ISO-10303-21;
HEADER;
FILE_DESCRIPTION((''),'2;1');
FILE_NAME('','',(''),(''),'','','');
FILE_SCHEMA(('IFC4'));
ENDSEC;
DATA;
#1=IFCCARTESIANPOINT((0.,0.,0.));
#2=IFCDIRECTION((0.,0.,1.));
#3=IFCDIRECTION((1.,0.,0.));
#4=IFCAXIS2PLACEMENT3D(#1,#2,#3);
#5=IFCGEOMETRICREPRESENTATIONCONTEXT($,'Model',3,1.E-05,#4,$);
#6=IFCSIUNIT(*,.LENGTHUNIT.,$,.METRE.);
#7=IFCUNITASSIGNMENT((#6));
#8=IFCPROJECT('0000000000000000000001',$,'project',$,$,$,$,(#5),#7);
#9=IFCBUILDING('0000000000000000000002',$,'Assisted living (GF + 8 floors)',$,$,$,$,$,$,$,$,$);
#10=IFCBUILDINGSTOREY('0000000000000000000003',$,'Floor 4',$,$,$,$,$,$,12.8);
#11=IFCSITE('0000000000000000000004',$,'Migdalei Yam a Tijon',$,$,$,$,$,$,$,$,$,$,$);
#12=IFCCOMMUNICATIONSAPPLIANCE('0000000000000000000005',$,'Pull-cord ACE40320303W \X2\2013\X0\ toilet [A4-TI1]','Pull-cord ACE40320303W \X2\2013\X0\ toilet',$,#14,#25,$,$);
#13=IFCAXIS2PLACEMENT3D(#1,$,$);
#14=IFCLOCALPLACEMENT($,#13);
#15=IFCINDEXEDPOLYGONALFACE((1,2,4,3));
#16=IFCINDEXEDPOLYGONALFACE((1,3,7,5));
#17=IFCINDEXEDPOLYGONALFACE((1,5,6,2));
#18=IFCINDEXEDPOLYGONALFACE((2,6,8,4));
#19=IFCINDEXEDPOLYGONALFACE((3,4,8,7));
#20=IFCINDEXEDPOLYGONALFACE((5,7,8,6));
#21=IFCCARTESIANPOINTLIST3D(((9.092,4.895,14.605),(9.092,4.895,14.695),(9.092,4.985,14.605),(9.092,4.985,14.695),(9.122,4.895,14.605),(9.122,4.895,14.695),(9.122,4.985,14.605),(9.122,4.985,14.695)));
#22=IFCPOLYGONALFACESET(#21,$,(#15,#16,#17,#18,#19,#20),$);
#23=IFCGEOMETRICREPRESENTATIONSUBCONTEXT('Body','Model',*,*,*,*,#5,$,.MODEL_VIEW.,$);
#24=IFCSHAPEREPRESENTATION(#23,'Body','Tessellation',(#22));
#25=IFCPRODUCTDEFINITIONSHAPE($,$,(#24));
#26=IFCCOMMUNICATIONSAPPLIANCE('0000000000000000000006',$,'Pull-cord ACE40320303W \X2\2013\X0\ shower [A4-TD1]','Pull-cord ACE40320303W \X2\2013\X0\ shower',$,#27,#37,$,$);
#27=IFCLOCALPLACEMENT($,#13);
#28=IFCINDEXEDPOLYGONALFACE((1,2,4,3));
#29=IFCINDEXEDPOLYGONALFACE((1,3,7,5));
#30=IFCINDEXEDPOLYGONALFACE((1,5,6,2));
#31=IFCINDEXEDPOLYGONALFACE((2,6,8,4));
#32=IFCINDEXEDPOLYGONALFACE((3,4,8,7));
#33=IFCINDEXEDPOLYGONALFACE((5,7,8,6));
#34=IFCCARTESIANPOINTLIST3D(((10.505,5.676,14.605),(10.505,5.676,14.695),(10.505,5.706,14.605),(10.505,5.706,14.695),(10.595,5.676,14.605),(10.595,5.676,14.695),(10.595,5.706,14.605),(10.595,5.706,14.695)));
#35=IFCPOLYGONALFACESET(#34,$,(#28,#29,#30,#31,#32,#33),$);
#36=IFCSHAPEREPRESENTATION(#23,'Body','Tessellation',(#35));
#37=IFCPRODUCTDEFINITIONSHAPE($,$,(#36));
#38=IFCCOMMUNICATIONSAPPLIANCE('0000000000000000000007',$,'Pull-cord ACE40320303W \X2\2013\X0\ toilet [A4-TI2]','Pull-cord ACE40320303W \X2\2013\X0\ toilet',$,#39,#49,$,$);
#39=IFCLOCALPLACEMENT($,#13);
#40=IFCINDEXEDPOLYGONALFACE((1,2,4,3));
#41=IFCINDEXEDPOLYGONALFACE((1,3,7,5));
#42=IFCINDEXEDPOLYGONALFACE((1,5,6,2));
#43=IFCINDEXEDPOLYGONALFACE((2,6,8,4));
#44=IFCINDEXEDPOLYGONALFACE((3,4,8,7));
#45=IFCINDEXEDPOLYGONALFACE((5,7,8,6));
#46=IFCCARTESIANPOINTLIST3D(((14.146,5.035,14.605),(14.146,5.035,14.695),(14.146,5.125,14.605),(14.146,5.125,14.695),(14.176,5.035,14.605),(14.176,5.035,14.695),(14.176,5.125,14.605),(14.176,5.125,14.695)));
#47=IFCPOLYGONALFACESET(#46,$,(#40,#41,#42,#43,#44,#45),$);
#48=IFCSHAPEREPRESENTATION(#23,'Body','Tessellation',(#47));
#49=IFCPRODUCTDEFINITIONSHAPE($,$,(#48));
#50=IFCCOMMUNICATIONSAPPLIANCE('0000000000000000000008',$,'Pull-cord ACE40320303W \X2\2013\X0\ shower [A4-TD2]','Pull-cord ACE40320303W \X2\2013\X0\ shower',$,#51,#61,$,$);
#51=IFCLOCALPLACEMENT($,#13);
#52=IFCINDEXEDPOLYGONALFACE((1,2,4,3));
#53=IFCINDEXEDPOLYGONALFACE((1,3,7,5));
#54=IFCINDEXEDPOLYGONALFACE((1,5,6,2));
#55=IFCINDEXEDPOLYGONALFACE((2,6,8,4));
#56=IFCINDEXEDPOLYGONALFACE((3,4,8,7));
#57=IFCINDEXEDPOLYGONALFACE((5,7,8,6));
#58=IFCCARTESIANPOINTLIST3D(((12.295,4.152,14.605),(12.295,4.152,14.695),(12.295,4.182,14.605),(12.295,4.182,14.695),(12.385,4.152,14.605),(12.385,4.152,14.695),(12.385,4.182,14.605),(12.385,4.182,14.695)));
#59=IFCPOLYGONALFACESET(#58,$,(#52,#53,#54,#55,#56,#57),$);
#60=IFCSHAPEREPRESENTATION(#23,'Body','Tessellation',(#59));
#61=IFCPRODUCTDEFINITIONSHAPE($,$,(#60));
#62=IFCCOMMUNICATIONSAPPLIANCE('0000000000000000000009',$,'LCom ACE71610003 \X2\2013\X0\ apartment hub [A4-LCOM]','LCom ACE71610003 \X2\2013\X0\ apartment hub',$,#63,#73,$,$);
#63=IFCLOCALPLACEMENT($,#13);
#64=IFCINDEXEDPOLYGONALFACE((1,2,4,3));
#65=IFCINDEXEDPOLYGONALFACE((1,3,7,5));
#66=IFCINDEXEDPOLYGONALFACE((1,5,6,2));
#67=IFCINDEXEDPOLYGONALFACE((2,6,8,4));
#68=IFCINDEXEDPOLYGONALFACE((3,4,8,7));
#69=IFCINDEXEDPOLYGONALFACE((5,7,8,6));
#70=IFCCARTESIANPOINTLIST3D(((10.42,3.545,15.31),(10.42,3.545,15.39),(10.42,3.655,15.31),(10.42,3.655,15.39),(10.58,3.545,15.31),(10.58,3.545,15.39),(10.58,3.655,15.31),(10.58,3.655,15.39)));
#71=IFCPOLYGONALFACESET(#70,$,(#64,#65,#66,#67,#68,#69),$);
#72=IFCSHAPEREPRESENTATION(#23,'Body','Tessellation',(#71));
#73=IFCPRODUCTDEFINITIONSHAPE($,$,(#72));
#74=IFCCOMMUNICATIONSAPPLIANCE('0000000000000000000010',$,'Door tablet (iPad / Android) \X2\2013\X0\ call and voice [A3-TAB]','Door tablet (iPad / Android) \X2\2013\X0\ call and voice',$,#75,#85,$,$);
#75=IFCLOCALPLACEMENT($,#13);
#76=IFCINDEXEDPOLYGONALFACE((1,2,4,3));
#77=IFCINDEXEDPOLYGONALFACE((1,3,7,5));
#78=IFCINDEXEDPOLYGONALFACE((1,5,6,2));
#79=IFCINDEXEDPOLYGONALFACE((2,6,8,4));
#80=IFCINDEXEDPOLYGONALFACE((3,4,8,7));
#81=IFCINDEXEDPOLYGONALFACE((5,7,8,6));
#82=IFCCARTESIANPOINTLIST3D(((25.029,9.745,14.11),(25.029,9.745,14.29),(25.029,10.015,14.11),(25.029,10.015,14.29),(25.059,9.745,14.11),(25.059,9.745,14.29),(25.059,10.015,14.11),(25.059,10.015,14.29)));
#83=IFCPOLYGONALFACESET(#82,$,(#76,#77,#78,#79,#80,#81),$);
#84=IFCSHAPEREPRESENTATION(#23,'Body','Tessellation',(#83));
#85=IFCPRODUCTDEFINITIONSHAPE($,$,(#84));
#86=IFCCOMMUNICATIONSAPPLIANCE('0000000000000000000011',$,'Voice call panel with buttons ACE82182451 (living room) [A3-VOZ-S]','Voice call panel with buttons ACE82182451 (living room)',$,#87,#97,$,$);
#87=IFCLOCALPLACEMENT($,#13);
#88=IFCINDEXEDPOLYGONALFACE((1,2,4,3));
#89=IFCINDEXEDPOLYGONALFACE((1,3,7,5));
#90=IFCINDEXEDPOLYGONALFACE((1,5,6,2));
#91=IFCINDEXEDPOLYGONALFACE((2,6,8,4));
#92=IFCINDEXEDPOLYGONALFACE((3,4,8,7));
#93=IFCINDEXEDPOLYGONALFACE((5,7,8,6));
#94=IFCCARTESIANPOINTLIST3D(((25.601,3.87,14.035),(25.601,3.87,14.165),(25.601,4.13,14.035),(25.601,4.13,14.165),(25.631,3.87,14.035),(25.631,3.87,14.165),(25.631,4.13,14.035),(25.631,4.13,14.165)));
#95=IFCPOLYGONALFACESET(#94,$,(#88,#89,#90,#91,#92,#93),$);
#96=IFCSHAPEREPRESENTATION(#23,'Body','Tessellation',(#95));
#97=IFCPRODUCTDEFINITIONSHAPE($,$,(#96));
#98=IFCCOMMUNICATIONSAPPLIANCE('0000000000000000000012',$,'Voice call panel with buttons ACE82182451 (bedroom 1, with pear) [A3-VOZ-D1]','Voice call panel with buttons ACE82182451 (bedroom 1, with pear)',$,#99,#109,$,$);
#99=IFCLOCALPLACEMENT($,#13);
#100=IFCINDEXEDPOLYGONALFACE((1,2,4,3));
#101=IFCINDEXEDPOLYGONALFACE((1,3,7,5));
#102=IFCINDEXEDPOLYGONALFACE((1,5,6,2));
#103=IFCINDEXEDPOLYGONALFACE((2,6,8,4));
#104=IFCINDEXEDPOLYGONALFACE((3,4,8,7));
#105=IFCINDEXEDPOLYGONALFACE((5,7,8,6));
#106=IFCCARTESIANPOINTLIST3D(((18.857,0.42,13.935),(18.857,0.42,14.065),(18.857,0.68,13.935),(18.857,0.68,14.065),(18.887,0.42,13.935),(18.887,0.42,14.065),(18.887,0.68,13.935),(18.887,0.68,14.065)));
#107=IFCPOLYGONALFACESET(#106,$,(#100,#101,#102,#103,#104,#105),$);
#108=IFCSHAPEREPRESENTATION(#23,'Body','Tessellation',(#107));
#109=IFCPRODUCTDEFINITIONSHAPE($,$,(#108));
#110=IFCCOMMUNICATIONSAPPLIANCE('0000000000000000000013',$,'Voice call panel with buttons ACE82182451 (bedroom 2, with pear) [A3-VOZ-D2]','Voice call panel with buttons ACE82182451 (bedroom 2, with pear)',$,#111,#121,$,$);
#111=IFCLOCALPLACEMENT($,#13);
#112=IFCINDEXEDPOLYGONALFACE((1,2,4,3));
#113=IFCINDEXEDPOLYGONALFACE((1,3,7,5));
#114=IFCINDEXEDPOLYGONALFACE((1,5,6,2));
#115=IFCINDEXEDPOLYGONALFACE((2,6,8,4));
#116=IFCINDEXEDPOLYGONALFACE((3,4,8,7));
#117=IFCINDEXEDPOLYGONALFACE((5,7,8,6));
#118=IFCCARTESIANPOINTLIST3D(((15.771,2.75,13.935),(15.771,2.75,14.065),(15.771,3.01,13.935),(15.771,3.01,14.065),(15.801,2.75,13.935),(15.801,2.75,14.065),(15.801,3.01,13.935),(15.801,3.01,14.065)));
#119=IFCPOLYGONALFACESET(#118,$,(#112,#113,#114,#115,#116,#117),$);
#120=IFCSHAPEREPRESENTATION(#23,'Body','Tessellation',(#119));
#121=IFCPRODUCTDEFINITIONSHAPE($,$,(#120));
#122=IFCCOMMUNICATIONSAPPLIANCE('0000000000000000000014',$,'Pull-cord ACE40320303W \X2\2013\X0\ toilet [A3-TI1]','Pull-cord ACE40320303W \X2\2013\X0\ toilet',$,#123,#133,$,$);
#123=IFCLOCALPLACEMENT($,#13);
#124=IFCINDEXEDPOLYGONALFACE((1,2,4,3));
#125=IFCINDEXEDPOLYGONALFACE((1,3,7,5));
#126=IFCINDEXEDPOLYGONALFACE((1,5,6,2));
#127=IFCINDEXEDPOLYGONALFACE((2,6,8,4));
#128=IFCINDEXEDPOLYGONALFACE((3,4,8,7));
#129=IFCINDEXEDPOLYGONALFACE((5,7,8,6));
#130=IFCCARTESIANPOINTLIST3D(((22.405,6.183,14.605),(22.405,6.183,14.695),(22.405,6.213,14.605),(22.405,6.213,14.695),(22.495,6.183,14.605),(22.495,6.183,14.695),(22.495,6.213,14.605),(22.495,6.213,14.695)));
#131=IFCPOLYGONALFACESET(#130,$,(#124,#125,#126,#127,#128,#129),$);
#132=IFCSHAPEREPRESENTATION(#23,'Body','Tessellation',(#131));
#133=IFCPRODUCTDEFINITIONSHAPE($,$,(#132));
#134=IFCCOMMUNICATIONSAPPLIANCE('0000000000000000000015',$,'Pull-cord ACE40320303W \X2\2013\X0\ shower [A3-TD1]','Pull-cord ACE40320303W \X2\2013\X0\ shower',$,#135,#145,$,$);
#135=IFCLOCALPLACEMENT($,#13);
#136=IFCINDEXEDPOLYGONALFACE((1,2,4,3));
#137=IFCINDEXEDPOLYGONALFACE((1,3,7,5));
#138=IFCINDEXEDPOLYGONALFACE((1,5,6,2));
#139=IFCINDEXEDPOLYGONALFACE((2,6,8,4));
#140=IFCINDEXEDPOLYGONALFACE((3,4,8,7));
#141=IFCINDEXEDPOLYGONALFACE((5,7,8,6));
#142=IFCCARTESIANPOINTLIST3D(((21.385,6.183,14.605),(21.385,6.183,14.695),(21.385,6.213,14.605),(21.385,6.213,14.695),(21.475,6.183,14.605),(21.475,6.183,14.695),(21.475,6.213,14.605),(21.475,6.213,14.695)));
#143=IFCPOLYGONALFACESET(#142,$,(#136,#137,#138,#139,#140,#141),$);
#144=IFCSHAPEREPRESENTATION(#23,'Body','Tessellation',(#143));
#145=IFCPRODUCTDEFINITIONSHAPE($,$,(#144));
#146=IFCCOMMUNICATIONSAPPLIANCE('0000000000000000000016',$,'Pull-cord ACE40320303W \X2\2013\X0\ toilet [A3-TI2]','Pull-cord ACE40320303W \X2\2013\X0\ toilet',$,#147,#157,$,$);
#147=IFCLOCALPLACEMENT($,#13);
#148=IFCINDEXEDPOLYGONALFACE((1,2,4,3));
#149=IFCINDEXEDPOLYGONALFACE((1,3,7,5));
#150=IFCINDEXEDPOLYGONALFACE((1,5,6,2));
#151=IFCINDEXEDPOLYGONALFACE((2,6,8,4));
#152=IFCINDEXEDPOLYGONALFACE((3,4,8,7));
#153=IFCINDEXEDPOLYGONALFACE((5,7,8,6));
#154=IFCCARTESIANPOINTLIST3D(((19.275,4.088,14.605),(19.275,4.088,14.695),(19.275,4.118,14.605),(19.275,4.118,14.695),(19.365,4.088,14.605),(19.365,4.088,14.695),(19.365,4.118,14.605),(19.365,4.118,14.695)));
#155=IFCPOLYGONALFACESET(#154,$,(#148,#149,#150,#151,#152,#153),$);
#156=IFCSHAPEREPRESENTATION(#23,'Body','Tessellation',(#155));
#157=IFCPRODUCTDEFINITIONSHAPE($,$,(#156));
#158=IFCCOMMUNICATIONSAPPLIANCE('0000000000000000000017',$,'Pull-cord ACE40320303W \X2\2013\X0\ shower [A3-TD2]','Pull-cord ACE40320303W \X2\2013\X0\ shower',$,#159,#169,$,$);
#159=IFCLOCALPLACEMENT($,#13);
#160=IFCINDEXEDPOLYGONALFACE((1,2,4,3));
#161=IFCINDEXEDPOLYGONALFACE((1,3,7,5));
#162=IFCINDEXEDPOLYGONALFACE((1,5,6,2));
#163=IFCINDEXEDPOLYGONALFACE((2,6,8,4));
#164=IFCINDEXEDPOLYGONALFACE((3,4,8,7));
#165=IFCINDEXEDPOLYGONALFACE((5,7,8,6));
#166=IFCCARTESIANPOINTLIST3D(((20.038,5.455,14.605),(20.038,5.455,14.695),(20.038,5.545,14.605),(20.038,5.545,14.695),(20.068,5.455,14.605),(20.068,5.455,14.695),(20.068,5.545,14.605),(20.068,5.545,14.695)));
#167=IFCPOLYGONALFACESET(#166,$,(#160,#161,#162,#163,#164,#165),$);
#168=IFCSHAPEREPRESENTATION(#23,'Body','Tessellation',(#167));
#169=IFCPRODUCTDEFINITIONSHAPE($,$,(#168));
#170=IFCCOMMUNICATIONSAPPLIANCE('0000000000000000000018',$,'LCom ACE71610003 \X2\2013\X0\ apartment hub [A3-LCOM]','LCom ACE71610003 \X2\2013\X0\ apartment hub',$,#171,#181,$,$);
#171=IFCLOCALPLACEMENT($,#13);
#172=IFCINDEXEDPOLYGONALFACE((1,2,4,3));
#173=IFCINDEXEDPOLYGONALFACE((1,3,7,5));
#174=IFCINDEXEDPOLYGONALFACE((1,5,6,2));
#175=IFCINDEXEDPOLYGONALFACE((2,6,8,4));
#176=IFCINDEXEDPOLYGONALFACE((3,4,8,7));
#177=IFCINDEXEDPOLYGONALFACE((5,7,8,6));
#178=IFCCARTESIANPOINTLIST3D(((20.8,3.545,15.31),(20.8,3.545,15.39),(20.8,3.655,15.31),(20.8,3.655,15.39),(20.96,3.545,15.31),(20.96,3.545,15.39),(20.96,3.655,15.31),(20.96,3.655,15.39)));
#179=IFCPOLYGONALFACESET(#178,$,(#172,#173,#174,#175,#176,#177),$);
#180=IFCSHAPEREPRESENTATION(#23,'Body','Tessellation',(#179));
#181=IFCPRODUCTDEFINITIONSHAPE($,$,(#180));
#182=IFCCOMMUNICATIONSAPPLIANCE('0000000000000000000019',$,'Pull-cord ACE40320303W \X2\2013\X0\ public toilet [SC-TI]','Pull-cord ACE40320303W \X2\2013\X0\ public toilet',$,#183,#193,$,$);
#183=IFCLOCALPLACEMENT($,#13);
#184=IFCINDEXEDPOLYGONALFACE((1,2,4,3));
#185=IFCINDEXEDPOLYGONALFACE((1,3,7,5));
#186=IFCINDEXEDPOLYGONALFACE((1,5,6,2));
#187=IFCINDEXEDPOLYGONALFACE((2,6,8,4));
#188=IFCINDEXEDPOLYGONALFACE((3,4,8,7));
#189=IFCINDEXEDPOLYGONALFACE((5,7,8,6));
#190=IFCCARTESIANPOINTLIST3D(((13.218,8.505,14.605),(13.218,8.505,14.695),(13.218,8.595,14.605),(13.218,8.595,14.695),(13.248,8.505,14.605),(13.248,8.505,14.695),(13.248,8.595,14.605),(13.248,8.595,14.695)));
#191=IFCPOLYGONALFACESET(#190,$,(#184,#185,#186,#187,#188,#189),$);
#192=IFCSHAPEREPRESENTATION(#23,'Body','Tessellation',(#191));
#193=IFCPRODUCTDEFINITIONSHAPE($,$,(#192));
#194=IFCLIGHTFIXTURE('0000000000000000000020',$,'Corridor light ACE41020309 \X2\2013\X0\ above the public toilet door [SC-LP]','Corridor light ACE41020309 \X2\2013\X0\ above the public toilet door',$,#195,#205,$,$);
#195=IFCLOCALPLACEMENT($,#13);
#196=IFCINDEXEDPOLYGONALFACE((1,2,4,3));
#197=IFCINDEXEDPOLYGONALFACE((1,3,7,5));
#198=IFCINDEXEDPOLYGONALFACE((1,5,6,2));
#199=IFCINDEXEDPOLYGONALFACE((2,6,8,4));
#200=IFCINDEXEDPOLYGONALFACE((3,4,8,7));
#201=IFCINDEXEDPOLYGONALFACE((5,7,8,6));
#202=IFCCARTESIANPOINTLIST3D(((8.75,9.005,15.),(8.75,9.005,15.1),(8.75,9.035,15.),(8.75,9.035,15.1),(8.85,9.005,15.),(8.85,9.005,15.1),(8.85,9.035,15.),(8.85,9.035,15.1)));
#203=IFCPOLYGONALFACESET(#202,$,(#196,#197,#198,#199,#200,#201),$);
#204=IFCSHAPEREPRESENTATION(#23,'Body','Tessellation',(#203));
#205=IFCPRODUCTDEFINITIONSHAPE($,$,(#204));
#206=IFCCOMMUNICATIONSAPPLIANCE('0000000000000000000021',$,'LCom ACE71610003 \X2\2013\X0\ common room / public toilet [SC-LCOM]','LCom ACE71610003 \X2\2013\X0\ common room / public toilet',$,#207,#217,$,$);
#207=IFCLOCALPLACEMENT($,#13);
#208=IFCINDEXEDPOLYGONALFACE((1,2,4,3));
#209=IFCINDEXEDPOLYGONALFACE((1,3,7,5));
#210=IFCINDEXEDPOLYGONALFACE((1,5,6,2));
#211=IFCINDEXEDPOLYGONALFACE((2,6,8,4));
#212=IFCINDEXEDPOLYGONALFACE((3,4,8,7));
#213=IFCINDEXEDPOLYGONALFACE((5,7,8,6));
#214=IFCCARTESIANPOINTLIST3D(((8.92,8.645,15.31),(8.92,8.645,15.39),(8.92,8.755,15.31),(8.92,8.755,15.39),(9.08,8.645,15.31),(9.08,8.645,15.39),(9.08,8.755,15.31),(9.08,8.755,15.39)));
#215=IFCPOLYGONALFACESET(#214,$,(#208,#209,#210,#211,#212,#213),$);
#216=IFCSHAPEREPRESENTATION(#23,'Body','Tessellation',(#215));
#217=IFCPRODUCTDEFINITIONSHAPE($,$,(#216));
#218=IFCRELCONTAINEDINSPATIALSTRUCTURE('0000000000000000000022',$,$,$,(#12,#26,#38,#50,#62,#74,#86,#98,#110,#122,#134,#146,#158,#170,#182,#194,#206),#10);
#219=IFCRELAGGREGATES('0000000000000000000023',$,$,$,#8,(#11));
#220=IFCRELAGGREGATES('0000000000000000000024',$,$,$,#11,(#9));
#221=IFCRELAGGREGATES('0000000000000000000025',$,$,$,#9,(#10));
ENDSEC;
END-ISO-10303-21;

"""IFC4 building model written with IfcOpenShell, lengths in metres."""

from ifc_helpers import new_model, si_unit, frame, origin_with_axes, context, subcontext, project, spatial, line, indexed_curve, outline, extrude, element, save


model = new_model("IFC4")

# Units and contexts
model_context = context("Model", 3, precision=1e-05, world=origin_with_axes())
body_context = subcontext(model_context, "Body", "Model", "MODEL_VIEW")
ifc_project = project(units=[si_unit("LENGTHUNIT", "METRE")], contexts=[model_context])

# Site, building, storey
site = spatial("IfcSite", under=ifc_project, Name="Migdalei Yam a Tijon")
building = spatial("IfcBuilding", under=site, Name="Assisted living (GF + 8 floors)")
storey = spatial("IfcBuildingStorey", under=building, Name="Floor 4", Elevation=12.8)

# Communications appliances
element("IfcCommunicationsAppliance", 1, inside=storey, Name="Pull-cord ACE40320303W – toilet [A4-TI1]", Description="Pull-cord ACE40320303W – toilet", context=body_context, shape_type="SweptSolid", body=[
    extrude(outline(indexed_curve([(0.0, 0.0), (0.03, 0.0), (0.03, 0.09), (0.0, 0.09)], segments=[line(1, 2, 3, 4, 1)])), frame((9.092, 4.895, 14.605), z_axis=(0.0, 0.0, 1.0), x_axis=(1.0, 0.0, 0.0)), (0.0, 0.0, 1.0), 0.09),
])
element("IfcCommunicationsAppliance", 2, inside=storey, Name="Pull-cord ACE40320303W – shower [A4-TD1]", Description="Pull-cord ACE40320303W – shower", context=body_context, shape_type="SweptSolid", body=[
    extrude(outline(indexed_curve([(0.0, 0.0), (0.09, 0.0), (0.09, 0.03), (0.0, 0.03)], segments=[line(1, 2, 3, 4, 1)])), frame((10.505, 5.676, 14.605), z_axis=(0.0, 0.0, 1.0), x_axis=(1.0, 0.0, 0.0)), (0.0, 0.0, 1.0), 0.09),
])
element("IfcCommunicationsAppliance", 3, inside=storey, Name="Pull-cord ACE40320303W – toilet [A4-TI2]", Description="Pull-cord ACE40320303W – toilet", context=body_context, shape_type="SweptSolid", body=[
    extrude(outline(indexed_curve([(0.0, 0.0), (0.03, 0.0), (0.03, 0.09), (0.0, 0.09)], segments=[line(1, 2, 3, 4, 1)])), frame((14.146, 5.035, 14.605), z_axis=(0.0, 0.0, 1.0), x_axis=(1.0, 0.0, 0.0)), (0.0, 0.0, 1.0), 0.09),
])
element("IfcCommunicationsAppliance", 4, inside=storey, Name="Pull-cord ACE40320303W – shower [A4-TD2]", Description="Pull-cord ACE40320303W – shower", context=body_context, shape_type="SweptSolid", body=[
    extrude(outline(indexed_curve([(0.0, 0.0), (0.09, 0.0), (0.09, 0.03), (0.0, 0.03)], segments=[line(1, 2, 3, 4, 1)])), frame((12.295, 4.152, 14.605), z_axis=(0.0, 0.0, 1.0), x_axis=(1.0, 0.0, 0.0)), (0.0, 0.0, 1.0), 0.09),
])
element("IfcCommunicationsAppliance", 5, inside=storey, Name="LCom ACE71610003 – apartment hub [A4-LCOM]", Description="LCom ACE71610003 – apartment hub", context=body_context, shape_type="SweptSolid", body=[
    extrude(outline(indexed_curve([(0.0, 0.0), (0.16, 0.0), (0.16, 0.11), (0.0, 0.11)], segments=[line(1, 2, 3, 4, 1)])), frame((10.42, 3.545, 15.31), z_axis=(0.0, 0.0, 1.0), x_axis=(1.0, 0.0, 0.0)), (0.0, 0.0, 1.0), 0.08),
])
element("IfcCommunicationsAppliance", 6, inside=storey, Name="Door tablet (iPad / Android) – call and voice [A3-TAB]", Description="Door tablet (iPad / Android) – call and voice", context=body_context, shape_type="SweptSolid", body=[
    extrude(outline(indexed_curve([(0.0, 0.0), (0.03, 0.0), (0.03, 0.27), (0.0, 0.27)], segments=[line(1, 2, 3, 4, 1)])), frame((25.029, 9.745, 14.11), z_axis=(0.0, 0.0, 1.0), x_axis=(1.0, 0.0, 0.0)), (0.0, 0.0, 1.0), 0.18),
])
element("IfcCommunicationsAppliance", 7, inside=storey, Name="Voice call panel with buttons ACE82182451 (living room) [A3-VOZ-S]", Description="Voice call panel with buttons ACE82182451 (living room)", context=body_context, shape_type="SweptSolid", body=[
    extrude(outline(indexed_curve([(0.0, 0.0), (0.03, 0.0), (0.03, 0.26), (0.0, 0.26)], segments=[line(1, 2, 3, 4, 1)])), frame((25.601, 3.87, 14.035), z_axis=(0.0, 0.0, 1.0), x_axis=(1.0, 0.0, 0.0)), (0.0, 0.0, 1.0), 0.13),
])
element("IfcCommunicationsAppliance", 8, inside=storey, Name="Voice call panel with buttons ACE82182451 (bedroom 1, with pear) [A3-VOZ-D1]", Description="Voice call panel with buttons ACE82182451 (bedroom 1, with pear)", context=body_context, shape_type="SweptSolid", body=[
    extrude(outline(indexed_curve([(0.0, 0.0), (0.03, 0.0), (0.03, 0.26), (0.0, 0.26)], segments=[line(1, 2, 3, 4, 1)])), frame((18.857, 0.42, 13.935), z_axis=(0.0, 0.0, 1.0), x_axis=(1.0, 0.0, 0.0)), (0.0, 0.0, 1.0), 0.13),
])
element("IfcCommunicationsAppliance", 9, inside=storey, Name="Voice call panel with buttons ACE82182451 (bedroom 2, with pear) [A3-VOZ-D2]", Description="Voice call panel with buttons ACE82182451 (bedroom 2, with pear)", context=body_context, shape_type="SweptSolid", body=[
    extrude(outline(indexed_curve([(0.0, 0.0), (0.03, 0.0), (0.03, 0.26), (0.0, 0.26)], segments=[line(1, 2, 3, 4, 1)])), frame((15.771, 2.75, 13.935), z_axis=(0.0, 0.0, 1.0), x_axis=(1.0, 0.0, 0.0)), (0.0, 0.0, 1.0), 0.13),
])
element("IfcCommunicationsAppliance", 10, inside=storey, Name="Pull-cord ACE40320303W – toilet [A3-TI1]", Description="Pull-cord ACE40320303W – toilet", context=body_context, shape_type="SweptSolid", body=[
    extrude(outline(indexed_curve([(0.0, 0.0), (0.09, 0.0), (0.09, 0.03), (0.0, 0.03)], segments=[line(1, 2, 3, 4, 1)])), frame((22.405, 6.183, 14.605), z_axis=(0.0, 0.0, 1.0), x_axis=(1.0, 0.0, 0.0)), (0.0, 0.0, 1.0), 0.09),
])
element("IfcCommunicationsAppliance", 11, inside=storey, Name="Pull-cord ACE40320303W – shower [A3-TD1]", Description="Pull-cord ACE40320303W – shower", context=body_context, shape_type="SweptSolid", body=[
    extrude(outline(indexed_curve([(0.0, 0.0), (0.09, 0.0), (0.09, 0.03), (0.0, 0.03)], segments=[line(1, 2, 3, 4, 1)])), frame((21.385, 6.183, 14.605), z_axis=(0.0, 0.0, 1.0), x_axis=(1.0, 0.0, 0.0)), (0.0, 0.0, 1.0), 0.09),
])
element("IfcCommunicationsAppliance", 12, inside=storey, Name="Pull-cord ACE40320303W – toilet [A3-TI2]", Description="Pull-cord ACE40320303W – toilet", context=body_context, shape_type="SweptSolid", body=[
    extrude(outline(indexed_curve([(0.0, 0.0), (0.09, 0.0), (0.09, 0.03), (0.0, 0.03)], segments=[line(1, 2, 3, 4, 1)])), frame((19.275, 4.088, 14.605), z_axis=(0.0, 0.0, 1.0), x_axis=(1.0, 0.0, 0.0)), (0.0, 0.0, 1.0), 0.09),
])
element("IfcCommunicationsAppliance", 13, inside=storey, Name="Pull-cord ACE40320303W – shower [A3-TD2]", Description="Pull-cord ACE40320303W – shower", context=body_context, shape_type="SweptSolid", body=[
    extrude(outline(indexed_curve([(0.0, 0.0), (0.03, 0.0), (0.03, 0.09), (0.0, 0.09)], segments=[line(1, 2, 3, 4, 1)])), frame((20.038, 5.455, 14.605), z_axis=(0.0, 0.0, 1.0), x_axis=(1.0, 0.0, 0.0)), (0.0, 0.0, 1.0), 0.09),
])
element("IfcCommunicationsAppliance", 14, inside=storey, Name="LCom ACE71610003 – apartment hub [A3-LCOM]", Description="LCom ACE71610003 – apartment hub", context=body_context, shape_type="SweptSolid", body=[
    extrude(outline(indexed_curve([(0.0, 0.0), (0.16, 0.0), (0.16, 0.11), (0.0, 0.11)], segments=[line(1, 2, 3, 4, 1)])), frame((20.8, 3.545, 15.31), z_axis=(0.0, 0.0, 1.0), x_axis=(1.0, 0.0, 0.0)), (0.0, 0.0, 1.0), 0.08),
])
element("IfcCommunicationsAppliance", 15, inside=storey, Name="Pull-cord ACE40320303W – public toilet [SC-TI]", Description="Pull-cord ACE40320303W – public toilet", context=body_context, shape_type="SweptSolid", body=[
    extrude(outline(indexed_curve([(0.0, 0.0), (0.03, 0.0), (0.03, 0.09), (0.0, 0.09)], segments=[line(1, 2, 3, 4, 1)])), frame((13.218, 8.505, 14.605), z_axis=(0.0, 0.0, 1.0), x_axis=(1.0, 0.0, 0.0)), (0.0, 0.0, 1.0), 0.09),
])

# Light fixture
element("IfcLightFixture", 16, inside=storey, Name="Corridor light ACE41020309 – above the public toilet door [SC-LP]", Description="Corridor light ACE41020309 – above the public toilet door", context=body_context, shape_type="SweptSolid", body=[
    extrude(outline(indexed_curve([(0.0, 0.0), (0.1, 0.0), (0.1, 0.03), (0.0, 0.03)], segments=[line(1, 2, 3, 4, 1)])), frame((8.75, 9.005, 15.0), z_axis=(0.0, 0.0, 1.0), x_axis=(1.0, 0.0, 0.0)), (0.0, 0.0, 1.0), 0.1),
])

# Communications appliance
element("IfcCommunicationsAppliance", 17, inside=storey, Name="LCom ACE71610003 – common room / public toilet [SC-LCOM]", Description="LCom ACE71610003 – common room / public toilet", context=body_context, shape_type="SweptSolid", body=[
    extrude(outline(indexed_curve([(0.0, 0.0), (0.16, 0.0), (0.16, 0.11), (0.0, 0.11)], segments=[line(1, 2, 3, 4, 1)])), frame((8.92, 8.645, 15.31), z_axis=(0.0, 0.0, 1.0), x_axis=(1.0, 0.0, 0.0)), (0.0, 0.0, 1.0), 0.08),
])

save(model, "model.ifc")
